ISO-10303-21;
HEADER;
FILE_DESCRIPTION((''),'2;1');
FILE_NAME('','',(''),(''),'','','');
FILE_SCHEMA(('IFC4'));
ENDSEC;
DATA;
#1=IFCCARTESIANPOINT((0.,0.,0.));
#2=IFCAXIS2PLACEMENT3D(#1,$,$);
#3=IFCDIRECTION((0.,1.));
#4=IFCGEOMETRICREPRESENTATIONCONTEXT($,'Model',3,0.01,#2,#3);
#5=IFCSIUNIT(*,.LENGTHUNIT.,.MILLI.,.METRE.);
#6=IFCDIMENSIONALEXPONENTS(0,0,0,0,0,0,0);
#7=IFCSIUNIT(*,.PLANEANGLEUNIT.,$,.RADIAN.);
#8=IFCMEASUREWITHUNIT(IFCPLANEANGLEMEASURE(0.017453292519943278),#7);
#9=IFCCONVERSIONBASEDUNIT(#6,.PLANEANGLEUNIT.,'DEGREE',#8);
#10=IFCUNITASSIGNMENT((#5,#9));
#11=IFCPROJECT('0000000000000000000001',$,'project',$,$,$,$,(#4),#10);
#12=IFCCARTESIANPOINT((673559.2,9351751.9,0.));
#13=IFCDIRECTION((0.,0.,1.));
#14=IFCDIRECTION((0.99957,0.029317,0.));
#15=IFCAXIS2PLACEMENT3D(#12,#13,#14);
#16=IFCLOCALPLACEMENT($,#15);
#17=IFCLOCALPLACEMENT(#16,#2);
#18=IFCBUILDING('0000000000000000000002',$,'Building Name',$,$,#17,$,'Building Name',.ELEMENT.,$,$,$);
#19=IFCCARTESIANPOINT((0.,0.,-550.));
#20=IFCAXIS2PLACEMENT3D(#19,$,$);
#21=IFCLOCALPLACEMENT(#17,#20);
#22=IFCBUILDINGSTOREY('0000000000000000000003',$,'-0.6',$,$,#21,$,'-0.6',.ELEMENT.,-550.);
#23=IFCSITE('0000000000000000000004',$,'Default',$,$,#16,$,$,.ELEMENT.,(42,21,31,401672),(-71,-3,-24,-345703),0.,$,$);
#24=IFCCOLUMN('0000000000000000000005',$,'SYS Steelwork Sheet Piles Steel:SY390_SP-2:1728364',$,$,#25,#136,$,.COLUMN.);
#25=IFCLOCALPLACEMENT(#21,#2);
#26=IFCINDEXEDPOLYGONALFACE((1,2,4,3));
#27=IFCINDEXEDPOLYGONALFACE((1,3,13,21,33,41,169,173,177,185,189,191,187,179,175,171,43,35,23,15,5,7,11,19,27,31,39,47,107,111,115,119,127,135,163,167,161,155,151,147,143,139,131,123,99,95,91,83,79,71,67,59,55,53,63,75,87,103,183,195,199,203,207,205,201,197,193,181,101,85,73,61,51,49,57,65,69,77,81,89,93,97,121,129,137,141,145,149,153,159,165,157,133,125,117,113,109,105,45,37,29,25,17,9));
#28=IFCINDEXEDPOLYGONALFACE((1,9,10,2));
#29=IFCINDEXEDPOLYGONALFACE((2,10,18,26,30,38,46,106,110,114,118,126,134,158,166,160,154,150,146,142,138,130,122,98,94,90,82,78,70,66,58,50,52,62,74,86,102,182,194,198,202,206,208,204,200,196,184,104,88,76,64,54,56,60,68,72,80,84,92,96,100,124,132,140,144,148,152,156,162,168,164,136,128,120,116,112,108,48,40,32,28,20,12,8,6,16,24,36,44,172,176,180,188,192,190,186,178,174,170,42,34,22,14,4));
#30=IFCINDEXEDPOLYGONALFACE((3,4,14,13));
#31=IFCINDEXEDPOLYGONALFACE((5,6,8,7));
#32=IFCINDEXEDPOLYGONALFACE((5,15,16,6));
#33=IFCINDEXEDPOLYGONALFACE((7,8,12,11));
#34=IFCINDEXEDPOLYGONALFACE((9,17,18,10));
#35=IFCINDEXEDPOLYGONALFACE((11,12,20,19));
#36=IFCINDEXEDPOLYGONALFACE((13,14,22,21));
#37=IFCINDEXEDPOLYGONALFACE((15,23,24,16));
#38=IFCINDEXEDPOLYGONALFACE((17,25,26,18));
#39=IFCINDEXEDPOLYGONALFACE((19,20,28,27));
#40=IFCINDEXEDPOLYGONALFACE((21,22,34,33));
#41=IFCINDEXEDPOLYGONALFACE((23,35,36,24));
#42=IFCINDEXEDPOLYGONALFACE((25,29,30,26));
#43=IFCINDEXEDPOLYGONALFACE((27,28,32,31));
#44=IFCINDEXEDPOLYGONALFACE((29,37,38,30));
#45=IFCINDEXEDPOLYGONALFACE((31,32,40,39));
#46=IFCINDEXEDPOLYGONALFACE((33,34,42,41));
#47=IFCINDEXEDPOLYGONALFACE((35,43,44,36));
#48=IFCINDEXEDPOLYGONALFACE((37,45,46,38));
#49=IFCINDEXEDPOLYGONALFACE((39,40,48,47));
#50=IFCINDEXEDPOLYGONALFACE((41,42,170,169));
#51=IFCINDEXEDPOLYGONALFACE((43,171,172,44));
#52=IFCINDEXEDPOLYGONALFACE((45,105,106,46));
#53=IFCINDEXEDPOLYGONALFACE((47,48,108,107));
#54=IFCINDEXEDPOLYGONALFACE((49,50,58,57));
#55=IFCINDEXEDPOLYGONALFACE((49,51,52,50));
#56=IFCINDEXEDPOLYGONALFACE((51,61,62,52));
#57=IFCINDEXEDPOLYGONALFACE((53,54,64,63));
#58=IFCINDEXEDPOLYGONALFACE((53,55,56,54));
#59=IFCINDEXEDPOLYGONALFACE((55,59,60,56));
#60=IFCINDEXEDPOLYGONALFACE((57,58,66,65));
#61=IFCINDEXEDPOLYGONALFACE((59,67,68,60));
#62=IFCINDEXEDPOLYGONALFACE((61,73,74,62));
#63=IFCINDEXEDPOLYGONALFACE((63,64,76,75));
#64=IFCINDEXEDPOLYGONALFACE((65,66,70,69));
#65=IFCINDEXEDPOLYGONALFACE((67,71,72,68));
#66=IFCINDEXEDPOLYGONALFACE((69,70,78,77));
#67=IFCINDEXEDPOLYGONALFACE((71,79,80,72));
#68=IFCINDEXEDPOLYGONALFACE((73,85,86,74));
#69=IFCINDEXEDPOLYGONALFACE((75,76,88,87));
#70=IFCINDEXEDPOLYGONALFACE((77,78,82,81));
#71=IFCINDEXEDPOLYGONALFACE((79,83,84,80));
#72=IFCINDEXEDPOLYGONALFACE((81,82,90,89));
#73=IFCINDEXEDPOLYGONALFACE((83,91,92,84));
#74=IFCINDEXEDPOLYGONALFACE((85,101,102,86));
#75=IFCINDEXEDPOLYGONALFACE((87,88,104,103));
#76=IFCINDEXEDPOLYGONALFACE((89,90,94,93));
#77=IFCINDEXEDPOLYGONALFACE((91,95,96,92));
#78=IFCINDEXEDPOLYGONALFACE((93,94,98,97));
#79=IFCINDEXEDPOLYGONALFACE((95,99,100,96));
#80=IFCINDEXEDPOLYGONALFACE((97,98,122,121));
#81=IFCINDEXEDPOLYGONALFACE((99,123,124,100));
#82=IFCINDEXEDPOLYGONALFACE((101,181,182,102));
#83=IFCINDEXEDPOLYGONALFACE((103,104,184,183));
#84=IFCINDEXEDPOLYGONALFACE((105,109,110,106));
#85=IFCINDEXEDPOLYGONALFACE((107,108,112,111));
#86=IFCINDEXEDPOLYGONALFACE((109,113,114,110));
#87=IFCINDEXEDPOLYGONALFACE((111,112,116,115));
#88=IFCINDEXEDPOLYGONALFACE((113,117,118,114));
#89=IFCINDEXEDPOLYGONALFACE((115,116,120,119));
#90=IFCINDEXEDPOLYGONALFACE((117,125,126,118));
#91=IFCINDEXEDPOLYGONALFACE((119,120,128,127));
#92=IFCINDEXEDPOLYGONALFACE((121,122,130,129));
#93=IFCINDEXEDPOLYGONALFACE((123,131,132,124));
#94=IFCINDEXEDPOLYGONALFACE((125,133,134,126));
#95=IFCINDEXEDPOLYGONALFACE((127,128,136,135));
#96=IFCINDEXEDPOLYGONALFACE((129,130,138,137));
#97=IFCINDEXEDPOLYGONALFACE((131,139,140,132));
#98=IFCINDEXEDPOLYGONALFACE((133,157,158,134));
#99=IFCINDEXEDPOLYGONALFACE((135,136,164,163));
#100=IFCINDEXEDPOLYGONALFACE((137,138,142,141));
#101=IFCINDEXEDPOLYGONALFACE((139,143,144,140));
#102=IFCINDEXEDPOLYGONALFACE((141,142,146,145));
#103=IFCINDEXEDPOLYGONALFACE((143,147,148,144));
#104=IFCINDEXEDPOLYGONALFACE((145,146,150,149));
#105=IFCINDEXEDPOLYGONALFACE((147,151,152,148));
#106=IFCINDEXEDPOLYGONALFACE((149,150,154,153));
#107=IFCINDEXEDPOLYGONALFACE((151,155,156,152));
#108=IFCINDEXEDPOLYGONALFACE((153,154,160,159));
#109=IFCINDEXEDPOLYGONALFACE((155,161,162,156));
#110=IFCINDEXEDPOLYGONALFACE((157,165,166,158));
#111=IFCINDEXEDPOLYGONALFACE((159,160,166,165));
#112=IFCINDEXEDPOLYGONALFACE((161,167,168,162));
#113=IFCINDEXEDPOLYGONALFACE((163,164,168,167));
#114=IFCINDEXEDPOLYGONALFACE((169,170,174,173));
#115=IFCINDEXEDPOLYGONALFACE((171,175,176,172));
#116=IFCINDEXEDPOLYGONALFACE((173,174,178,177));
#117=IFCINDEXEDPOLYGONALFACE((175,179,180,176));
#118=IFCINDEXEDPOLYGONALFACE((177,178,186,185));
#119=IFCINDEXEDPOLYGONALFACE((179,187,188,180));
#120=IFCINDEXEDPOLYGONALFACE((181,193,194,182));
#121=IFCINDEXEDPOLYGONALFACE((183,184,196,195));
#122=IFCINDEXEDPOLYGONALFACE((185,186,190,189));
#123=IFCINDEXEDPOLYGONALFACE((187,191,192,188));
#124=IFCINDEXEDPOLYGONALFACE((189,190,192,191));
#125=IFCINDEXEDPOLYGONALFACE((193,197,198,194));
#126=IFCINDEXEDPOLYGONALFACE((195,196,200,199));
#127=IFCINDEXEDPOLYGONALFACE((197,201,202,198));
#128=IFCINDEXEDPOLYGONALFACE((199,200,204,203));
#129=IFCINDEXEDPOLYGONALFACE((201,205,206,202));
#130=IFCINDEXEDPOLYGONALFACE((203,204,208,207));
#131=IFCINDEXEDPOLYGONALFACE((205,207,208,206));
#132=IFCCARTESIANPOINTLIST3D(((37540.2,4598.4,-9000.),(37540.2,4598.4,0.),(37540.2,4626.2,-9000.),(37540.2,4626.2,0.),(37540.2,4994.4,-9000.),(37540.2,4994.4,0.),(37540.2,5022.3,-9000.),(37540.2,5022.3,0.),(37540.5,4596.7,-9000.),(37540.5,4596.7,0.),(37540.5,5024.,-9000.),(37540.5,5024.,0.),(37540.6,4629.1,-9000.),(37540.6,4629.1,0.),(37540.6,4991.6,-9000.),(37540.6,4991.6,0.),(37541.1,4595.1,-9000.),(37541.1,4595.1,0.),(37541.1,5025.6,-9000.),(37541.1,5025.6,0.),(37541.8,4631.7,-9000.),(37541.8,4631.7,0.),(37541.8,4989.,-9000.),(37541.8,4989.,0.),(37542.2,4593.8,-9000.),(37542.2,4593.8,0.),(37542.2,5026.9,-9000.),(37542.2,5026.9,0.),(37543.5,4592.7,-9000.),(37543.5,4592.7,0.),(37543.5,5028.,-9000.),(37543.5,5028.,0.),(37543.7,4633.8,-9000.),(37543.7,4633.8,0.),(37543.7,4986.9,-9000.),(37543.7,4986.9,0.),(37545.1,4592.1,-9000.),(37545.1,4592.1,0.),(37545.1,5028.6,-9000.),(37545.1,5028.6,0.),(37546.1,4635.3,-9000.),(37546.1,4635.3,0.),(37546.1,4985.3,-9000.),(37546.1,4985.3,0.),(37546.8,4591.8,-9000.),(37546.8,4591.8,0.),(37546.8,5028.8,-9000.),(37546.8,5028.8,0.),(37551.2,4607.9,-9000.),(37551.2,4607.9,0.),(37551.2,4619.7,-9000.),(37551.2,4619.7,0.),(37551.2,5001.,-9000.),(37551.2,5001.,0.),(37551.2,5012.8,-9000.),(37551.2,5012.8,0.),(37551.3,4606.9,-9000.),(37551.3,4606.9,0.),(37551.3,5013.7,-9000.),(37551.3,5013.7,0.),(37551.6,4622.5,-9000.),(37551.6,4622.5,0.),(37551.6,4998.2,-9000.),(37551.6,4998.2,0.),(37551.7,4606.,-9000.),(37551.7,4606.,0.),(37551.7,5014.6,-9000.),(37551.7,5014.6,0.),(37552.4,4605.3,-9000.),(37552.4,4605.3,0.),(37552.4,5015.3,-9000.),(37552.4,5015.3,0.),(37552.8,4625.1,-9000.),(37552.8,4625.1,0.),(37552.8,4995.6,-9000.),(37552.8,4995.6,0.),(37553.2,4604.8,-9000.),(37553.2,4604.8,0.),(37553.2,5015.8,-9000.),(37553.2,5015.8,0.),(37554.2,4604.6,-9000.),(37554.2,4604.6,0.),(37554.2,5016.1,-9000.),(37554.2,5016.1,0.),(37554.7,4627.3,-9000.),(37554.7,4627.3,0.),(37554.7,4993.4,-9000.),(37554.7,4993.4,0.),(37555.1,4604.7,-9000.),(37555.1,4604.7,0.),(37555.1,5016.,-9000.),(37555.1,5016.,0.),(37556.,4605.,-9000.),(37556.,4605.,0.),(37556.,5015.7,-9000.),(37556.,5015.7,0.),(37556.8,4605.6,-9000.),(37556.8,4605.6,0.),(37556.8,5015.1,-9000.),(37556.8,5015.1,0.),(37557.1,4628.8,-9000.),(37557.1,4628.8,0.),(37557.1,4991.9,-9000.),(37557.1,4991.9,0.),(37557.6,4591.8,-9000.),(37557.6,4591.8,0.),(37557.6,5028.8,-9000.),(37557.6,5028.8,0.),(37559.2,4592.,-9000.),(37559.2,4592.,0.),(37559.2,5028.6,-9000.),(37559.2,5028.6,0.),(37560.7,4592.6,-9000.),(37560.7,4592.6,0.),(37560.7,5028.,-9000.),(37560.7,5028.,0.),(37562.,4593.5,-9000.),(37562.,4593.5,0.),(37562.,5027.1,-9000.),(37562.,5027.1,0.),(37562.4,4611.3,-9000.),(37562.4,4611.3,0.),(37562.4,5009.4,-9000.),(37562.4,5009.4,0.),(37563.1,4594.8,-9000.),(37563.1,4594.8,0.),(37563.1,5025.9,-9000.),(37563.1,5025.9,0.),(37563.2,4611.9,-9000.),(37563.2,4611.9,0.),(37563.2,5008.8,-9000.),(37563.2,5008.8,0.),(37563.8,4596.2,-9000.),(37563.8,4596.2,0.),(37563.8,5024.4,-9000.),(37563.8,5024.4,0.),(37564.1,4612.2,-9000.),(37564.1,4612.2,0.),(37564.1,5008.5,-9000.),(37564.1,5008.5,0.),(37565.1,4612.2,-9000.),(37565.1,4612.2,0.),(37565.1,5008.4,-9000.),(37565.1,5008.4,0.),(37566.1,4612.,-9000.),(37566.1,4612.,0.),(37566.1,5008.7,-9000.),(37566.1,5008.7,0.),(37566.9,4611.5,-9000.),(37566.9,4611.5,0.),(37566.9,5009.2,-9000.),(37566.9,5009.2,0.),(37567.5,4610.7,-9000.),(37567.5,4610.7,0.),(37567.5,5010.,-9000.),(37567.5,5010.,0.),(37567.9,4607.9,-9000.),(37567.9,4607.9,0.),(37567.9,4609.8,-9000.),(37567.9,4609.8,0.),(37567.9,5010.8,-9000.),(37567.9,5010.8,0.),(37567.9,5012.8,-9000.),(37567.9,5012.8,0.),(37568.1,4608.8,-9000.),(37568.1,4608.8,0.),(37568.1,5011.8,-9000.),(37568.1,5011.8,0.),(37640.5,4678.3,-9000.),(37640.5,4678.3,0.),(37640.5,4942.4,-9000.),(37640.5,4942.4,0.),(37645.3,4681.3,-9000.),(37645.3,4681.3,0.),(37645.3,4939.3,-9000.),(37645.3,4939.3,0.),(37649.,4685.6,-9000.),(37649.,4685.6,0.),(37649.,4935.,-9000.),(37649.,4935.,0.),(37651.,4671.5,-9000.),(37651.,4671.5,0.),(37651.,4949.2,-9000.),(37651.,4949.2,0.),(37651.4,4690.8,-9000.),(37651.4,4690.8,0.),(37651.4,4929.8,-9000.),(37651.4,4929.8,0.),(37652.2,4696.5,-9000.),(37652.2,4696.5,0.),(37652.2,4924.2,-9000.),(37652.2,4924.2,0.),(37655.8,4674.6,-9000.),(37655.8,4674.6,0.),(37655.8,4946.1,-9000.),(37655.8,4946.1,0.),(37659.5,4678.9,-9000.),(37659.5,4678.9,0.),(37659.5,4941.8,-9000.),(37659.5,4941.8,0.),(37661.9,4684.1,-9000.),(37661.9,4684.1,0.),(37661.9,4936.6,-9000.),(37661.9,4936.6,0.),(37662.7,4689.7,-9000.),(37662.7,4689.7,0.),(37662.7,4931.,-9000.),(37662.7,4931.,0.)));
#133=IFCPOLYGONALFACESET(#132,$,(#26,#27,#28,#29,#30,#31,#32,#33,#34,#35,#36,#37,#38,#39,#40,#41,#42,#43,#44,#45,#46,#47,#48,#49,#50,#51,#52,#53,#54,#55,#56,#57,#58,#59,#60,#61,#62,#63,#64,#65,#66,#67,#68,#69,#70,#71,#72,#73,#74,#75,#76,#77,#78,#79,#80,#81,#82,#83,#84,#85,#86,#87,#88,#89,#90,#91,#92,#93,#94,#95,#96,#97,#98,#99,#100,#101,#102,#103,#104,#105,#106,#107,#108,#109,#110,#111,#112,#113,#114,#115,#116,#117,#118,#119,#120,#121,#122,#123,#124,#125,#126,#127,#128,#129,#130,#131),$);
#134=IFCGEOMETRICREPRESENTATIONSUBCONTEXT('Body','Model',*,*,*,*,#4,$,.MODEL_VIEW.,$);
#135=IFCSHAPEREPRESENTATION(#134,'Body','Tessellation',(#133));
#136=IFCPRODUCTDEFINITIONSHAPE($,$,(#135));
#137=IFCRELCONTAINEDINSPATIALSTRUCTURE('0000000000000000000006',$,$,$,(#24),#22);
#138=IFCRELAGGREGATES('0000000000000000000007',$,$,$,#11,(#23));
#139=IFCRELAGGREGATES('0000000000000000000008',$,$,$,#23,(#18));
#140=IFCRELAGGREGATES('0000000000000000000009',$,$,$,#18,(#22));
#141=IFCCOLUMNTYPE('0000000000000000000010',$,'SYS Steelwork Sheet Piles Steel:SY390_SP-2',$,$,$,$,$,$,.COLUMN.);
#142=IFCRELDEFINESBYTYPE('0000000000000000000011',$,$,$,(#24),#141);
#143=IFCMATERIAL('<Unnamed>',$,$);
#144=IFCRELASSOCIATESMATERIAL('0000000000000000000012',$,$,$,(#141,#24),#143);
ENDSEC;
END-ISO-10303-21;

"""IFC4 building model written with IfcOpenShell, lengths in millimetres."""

from ifc_helpers import new_model, entity, si_unit, converted_unit, direction, frame, origin, place, context, subcontext, project, spatial, line, arc, indexed_curve, outline, extrude, source, transform, mapped, material, type_object, type_shapes, element, save


model = new_model("IFC4")

# Units and contexts
model_context = context("Model", 3, precision=0.01, world=origin(), true_north=direction((0.0, 1.0)))
body_context = subcontext(model_context, "Body", "Model", "MODEL_VIEW")
ifc_project = project(units=[si_unit("LENGTHUNIT", "METRE", prefix="MILLI"), converted_unit("PLANEANGLEUNIT", "DEGREE", entity("IfcPlaneAngleMeasure", 0.017453292519943278), si_unit("PLANEANGLEUNIT", "RADIAN"), dimensions=[0, 0, 0, 0, 0, 0, 0])], contexts=[model_context])

# Site, building, storey
site_placement = place(None, frame((673559.2, 9351751.9, 0.0), z_axis=(0.0, 0.0, 1.0), x_axis=(0.99957, 0.029317, 0.0)))
site = spatial("IfcSite", under=ifc_project, at=site_placement, Name="Default", CompositionType="ELEMENT", RefLatitude=(42, 21, 31, 401672), RefLongitude=(-71, -3, -24, -345703), RefElevation=0.0)
building_placement = place(site_placement, origin())
building = spatial("IfcBuilding", under=site, at=building_placement, Name="Building Name", LongName="Building Name", CompositionType="ELEMENT")
storey_placement = place(building_placement, frame((0.0, 0.0, -550.0)))
storey = spatial("IfcBuildingStorey", under=building, at=storey_placement, Name="-0.6", LongName="-0.6", CompositionType="ELEMENT", Elevation=-550.0)

# Column
ifc_material_1 = material(Name="<Unnamed>")
column_type = type_object("IfcColumnType", Name="SYS Steelwork Sheet Piles Steel:SY390_SP-2", PredefinedType="COLUMN", material=ifc_material_1)
shared_shape = source(origin(), body_context, "Body", "SweptSolid", [
    extrude(outline(indexed_curve([(-120.6, 84.7), (-131.4, 81.6), (-138.8, 73.0), (-181.5, -20.9), (-185.2, -25.2), (-190.6, -26.8), (-202.5, -26.8), (-205.5, -24.8), (-204.8, -21.2), (-199.1, -15.5), (-198.6, -11.5), (-202.5, -10.1), (-214.1, -14.2), (-217.3, -16.6), (-218.5, -20.4), (-218.5, -31.2), (-216.6, -35.8), (-211.9, -37.8), (-184.1, -37.8), (-178.7, -36.2), (-175.0, -31.9), (-132.1, 62.5), (-124.7, 71.1), (-113.9, 74.2), (113.9, 74.2), (124.7, 71.1), (132.1, 62.5), (175.0, -31.9), (178.7, -36.2), (184.1, -37.8), (211.9, -37.8), (216.6, -35.8), (218.5, -31.2), (218.5, -20.4), (217.3, -16.6), (214.1, -14.2), (202.5, -10.1), (198.6, -11.5), (199.1, -15.5), (204.8, -21.2), (205.5, -24.8), (202.5, -26.8), (190.6, -26.8), (185.2, -25.2), (181.5, -20.9), (138.8, 73.0), (131.4, 81.6), (120.6, 84.7)], segments=[arc(1, 2, 3), line(3, 4), arc(4, 5, 6), line(6, 7), arc(7, 8, 9), line(9, 10), arc(10, 11, 12), line(12, 13), arc(13, 14, 15), line(15, 16), arc(16, 17, 18), line(18, 19), arc(19, 20, 21), line(21, 22), arc(22, 23, 24), line(24, 25), arc(25, 26, 27), line(27, 28), arc(28, 29, 30), line(30, 31), arc(31, 32, 33), line(33, 34), arc(34, 35, 36), line(36, 37), arc(37, 38, 39), line(39, 40), arc(40, 41, 42), line(42, 43), arc(43, 44, 45), line(45, 46), arc(46, 47, 48), line(48, 1)], self_intersect=False)), frame((0.0, 15.3, -9550.0)), (0.0, 0.0, 1.0), 9000.0),
])
type_shapes(column_type, [shared_shape])
for number, where, z_axis, x_axis, name in (
    (1, (37562.7, 4810.3, 550.0), (0.0, 0.0, 1.0), (0.0, -1.0, 0.0), "SYS Steelwork Sheet Piles Steel:SY390_SP-2:1728364"),
):
    element("IfcColumn", number, at=place(storey_placement, frame(where, z_axis=z_axis, x_axis=x_axis)), inside=storey, type_object=column_type, material=ifc_material_1, Name=name, PredefinedType="COLUMN", context=body_context, shape_type="MappedRepresentation", body=[
        mapped(shared_shape, transform((0.0, 0.0, 0.0), scale=1.0)),
    ])

save(model, "model.ifc")
